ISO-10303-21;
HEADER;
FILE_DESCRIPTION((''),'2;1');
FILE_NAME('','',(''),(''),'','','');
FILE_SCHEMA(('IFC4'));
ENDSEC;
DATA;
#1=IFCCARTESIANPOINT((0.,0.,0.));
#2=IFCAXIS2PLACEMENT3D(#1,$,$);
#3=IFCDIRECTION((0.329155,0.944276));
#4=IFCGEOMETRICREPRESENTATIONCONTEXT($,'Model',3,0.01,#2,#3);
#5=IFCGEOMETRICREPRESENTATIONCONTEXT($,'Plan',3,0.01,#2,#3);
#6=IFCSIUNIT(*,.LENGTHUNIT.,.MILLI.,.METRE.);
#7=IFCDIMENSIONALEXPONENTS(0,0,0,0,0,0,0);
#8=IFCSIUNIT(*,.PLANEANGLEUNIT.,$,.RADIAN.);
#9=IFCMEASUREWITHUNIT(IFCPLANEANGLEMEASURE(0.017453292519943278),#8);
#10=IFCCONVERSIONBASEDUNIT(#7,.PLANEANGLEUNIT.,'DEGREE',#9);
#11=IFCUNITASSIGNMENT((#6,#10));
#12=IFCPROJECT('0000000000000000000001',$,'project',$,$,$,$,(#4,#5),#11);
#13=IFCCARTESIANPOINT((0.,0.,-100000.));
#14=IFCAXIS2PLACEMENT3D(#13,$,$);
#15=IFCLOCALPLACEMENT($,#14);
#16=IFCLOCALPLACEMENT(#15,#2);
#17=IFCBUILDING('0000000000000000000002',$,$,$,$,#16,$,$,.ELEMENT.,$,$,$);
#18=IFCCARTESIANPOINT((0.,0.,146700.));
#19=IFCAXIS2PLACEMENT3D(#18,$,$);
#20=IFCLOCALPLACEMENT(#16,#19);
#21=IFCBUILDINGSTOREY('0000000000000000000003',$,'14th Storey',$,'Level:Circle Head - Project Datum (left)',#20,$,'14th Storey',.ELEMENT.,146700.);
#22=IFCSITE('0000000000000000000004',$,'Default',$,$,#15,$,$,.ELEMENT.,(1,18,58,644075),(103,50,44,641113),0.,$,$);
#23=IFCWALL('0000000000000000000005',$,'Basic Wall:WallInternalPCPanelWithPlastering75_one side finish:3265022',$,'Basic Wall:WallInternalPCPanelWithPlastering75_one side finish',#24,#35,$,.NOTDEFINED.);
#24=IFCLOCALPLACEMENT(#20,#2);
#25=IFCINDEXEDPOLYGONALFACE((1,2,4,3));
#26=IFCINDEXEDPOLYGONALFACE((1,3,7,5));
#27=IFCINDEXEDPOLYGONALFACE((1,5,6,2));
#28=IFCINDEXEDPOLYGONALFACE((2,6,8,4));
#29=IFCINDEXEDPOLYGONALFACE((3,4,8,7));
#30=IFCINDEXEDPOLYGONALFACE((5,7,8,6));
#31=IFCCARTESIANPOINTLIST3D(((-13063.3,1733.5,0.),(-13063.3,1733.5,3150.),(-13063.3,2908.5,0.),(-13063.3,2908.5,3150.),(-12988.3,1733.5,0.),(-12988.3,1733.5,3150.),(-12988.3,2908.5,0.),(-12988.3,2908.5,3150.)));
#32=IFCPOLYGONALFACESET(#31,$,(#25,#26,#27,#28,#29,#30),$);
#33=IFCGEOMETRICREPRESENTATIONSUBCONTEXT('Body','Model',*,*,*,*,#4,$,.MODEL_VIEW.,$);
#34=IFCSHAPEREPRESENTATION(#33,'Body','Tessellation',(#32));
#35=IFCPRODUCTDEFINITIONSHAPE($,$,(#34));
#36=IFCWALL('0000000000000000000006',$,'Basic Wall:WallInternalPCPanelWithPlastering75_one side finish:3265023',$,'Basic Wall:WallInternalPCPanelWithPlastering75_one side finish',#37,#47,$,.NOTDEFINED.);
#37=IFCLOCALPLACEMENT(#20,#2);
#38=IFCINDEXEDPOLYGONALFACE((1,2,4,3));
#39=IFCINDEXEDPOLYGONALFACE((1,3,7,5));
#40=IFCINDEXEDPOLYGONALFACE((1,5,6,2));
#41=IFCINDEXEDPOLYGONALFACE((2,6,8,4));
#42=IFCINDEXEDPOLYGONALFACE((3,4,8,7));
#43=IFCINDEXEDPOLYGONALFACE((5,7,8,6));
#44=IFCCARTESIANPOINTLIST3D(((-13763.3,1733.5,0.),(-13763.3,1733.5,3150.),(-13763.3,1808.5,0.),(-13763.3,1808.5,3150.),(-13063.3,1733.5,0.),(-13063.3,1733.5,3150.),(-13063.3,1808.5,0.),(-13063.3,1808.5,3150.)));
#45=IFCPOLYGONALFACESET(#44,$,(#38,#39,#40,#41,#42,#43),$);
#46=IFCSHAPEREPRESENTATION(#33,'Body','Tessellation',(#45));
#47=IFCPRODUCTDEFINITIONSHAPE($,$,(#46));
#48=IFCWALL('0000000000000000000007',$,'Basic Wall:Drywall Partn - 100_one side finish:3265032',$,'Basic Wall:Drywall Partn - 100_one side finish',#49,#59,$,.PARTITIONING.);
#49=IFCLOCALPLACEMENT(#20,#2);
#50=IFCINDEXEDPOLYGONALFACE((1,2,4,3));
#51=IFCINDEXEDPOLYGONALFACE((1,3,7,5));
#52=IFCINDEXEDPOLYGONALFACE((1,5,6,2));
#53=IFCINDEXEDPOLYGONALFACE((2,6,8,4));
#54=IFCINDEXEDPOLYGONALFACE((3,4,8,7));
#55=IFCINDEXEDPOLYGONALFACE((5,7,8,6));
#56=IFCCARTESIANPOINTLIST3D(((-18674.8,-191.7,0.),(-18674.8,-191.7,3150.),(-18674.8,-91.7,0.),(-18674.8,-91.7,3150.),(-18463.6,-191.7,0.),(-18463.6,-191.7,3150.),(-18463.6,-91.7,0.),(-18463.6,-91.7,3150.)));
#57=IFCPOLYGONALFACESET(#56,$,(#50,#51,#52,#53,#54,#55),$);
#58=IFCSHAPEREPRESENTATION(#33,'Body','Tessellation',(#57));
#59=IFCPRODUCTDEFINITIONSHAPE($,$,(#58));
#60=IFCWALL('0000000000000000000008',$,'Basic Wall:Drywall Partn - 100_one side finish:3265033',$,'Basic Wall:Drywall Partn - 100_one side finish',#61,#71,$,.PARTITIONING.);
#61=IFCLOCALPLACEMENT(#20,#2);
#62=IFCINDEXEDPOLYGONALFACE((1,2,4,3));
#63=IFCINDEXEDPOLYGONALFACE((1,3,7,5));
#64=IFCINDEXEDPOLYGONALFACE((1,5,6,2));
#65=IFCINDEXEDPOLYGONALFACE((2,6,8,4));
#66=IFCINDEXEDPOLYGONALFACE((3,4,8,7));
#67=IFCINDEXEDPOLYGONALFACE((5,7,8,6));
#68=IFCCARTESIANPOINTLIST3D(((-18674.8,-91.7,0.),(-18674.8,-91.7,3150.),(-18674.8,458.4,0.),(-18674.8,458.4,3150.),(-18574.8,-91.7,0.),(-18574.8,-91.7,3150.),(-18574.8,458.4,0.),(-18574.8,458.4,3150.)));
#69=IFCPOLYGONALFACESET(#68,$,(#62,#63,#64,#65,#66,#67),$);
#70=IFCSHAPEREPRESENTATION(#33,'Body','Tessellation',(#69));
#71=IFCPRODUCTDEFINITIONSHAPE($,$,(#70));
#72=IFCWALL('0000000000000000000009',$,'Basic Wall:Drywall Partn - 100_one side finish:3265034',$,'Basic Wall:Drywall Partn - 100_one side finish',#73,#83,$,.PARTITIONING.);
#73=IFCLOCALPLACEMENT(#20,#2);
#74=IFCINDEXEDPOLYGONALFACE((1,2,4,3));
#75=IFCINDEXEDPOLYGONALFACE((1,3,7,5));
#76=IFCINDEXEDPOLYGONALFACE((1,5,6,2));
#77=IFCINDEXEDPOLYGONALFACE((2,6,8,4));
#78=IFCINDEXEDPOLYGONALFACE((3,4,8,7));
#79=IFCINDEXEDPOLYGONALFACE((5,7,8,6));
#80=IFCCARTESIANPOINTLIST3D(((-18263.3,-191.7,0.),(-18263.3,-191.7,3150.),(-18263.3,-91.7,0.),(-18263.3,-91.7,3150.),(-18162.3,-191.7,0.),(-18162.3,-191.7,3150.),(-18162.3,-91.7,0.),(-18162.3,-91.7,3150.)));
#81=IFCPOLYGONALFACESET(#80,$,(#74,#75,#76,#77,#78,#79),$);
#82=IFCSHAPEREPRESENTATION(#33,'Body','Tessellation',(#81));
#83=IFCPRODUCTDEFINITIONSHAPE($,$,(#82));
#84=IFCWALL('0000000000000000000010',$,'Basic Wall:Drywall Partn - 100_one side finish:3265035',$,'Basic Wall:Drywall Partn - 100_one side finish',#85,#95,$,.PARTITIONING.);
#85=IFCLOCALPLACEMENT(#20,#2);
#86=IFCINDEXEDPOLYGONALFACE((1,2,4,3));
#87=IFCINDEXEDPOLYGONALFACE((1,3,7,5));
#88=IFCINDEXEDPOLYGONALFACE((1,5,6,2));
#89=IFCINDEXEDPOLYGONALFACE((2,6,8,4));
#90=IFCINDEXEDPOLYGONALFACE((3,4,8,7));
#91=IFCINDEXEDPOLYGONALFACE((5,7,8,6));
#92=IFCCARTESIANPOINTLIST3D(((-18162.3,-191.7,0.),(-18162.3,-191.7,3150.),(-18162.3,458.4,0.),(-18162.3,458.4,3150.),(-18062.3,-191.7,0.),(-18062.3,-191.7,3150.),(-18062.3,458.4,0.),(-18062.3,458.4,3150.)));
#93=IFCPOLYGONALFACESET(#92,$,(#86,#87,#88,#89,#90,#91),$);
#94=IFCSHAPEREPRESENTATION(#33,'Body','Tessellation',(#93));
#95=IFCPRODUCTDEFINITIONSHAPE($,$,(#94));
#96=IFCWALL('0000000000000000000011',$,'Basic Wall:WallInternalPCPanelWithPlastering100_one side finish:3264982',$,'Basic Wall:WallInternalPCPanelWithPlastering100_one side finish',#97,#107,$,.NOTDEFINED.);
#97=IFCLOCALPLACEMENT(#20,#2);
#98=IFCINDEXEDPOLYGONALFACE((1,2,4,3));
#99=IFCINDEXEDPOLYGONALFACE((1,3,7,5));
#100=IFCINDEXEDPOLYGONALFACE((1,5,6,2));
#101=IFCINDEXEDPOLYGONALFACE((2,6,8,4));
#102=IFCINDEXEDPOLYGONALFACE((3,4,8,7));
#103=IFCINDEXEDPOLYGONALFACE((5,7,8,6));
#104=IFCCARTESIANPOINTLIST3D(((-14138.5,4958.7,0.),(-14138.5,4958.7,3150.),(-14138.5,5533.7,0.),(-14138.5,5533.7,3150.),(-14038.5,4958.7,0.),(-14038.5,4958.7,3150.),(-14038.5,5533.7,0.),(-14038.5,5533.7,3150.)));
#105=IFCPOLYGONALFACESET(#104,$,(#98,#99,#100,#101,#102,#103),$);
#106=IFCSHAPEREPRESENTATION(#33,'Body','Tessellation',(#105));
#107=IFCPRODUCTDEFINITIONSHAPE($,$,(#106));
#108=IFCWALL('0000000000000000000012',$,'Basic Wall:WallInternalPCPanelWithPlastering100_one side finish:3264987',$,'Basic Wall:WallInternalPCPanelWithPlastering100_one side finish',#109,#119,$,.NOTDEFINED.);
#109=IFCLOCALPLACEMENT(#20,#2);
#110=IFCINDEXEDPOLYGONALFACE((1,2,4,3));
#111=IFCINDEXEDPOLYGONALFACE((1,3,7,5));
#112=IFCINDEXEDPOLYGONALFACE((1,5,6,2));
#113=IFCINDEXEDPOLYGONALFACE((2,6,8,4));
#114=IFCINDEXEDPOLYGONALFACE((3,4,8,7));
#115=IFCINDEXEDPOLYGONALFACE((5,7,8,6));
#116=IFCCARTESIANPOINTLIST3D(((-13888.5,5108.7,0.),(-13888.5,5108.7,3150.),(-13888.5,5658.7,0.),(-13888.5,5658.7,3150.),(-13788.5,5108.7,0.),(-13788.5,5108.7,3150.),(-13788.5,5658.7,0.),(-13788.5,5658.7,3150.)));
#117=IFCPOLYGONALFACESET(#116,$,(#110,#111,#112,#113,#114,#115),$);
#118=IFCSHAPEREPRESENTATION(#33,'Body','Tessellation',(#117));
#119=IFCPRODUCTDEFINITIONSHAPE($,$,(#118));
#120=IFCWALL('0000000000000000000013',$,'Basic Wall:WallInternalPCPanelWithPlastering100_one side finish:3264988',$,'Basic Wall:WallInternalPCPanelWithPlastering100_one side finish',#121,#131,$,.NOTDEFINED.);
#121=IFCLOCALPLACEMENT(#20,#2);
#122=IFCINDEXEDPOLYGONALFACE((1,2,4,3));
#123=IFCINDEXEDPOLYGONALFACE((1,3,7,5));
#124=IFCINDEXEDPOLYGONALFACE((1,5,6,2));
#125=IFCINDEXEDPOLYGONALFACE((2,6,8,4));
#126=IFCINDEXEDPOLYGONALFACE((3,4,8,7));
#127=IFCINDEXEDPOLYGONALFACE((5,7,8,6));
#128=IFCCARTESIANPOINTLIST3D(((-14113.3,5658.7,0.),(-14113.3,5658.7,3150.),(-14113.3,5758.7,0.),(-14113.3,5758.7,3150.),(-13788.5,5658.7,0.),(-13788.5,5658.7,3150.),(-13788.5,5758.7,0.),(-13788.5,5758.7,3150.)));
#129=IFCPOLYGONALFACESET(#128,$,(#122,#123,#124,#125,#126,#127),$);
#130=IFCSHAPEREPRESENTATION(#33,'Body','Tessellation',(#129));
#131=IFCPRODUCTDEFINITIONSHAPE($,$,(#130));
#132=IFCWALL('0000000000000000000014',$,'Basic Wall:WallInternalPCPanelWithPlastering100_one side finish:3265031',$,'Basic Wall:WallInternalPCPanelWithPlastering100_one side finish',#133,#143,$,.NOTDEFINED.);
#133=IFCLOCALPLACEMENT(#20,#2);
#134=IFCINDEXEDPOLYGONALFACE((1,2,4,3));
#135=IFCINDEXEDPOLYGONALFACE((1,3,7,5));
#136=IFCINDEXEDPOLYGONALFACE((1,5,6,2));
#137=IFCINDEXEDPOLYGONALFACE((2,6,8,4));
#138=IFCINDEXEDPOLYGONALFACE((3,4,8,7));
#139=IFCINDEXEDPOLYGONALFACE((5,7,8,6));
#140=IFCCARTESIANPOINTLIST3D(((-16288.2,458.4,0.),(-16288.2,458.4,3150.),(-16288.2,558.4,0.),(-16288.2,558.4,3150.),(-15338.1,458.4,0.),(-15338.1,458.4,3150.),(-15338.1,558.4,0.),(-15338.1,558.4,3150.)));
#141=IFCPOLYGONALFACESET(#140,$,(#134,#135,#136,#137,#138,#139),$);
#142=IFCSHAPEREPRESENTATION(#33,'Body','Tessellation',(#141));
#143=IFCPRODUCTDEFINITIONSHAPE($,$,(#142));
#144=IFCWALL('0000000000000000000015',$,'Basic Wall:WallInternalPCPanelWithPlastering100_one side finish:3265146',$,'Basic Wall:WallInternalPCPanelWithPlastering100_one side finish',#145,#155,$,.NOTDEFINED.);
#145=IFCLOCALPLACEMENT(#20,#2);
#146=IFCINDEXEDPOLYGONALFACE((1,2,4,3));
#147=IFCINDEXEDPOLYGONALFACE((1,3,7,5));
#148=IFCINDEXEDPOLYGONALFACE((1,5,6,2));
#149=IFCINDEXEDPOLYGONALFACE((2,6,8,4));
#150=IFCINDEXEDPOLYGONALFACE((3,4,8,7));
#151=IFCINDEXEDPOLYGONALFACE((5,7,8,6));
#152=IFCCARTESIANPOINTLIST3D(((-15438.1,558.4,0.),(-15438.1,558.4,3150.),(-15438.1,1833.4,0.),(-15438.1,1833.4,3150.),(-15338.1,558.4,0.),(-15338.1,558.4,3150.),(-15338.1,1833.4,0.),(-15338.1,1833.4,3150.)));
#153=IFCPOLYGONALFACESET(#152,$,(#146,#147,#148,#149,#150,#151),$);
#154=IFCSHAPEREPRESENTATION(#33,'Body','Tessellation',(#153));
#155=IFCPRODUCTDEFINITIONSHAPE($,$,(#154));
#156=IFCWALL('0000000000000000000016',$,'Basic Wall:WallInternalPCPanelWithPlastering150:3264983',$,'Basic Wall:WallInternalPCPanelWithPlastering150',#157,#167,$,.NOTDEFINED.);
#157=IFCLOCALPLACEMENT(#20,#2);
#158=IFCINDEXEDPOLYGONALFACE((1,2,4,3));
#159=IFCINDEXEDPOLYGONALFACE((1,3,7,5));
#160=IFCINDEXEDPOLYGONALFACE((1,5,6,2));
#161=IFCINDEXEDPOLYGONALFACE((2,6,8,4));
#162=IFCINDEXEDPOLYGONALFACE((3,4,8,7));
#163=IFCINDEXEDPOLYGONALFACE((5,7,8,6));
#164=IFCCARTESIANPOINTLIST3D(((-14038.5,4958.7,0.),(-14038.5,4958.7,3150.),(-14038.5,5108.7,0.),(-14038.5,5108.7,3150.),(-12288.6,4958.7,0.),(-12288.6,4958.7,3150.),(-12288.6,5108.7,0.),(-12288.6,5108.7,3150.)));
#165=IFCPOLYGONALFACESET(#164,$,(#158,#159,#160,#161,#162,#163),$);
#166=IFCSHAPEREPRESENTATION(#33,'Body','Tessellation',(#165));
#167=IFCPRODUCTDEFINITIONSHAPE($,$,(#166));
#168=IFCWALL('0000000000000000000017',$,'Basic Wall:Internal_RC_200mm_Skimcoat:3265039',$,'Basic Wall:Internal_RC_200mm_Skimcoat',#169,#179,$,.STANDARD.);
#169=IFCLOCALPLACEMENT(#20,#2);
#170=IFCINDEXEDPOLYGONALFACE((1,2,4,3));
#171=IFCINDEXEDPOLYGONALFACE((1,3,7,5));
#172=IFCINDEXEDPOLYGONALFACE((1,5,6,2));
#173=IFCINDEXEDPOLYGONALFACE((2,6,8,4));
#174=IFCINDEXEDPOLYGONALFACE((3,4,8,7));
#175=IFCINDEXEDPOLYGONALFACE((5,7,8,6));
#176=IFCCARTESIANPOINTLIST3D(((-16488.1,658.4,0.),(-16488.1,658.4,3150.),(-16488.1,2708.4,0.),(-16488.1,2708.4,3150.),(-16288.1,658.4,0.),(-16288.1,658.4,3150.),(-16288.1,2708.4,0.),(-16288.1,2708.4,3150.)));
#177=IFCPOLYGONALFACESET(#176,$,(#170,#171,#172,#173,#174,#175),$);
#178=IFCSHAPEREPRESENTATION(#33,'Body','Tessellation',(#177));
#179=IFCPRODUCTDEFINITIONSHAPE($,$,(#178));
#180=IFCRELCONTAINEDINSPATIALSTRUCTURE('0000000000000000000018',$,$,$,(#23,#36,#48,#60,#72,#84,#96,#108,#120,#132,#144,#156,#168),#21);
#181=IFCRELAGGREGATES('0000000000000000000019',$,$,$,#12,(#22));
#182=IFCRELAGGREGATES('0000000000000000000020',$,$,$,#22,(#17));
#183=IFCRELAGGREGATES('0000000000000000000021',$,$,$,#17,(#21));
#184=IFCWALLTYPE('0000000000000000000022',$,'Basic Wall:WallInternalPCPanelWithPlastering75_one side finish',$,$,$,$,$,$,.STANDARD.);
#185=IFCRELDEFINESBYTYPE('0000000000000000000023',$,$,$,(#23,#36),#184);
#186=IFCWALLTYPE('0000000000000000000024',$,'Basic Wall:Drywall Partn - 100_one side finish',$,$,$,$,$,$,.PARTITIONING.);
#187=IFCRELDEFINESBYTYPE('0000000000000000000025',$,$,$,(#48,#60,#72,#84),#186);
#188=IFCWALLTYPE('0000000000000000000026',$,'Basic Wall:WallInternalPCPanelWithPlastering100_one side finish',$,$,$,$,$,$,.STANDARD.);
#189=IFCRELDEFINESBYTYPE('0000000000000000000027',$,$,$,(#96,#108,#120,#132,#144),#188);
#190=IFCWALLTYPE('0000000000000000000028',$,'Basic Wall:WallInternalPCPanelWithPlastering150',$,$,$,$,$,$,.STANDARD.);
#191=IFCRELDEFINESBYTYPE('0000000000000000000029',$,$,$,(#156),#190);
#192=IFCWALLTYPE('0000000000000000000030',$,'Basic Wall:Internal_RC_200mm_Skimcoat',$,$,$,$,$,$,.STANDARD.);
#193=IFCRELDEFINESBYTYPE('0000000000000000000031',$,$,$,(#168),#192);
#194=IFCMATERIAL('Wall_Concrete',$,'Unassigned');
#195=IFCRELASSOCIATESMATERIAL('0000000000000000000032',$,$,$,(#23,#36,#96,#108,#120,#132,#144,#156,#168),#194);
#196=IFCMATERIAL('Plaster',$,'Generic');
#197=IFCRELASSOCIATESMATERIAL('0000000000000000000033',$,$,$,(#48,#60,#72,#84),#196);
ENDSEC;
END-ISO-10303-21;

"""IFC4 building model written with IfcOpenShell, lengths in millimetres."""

from ifc_helpers import new_model, entity, si_unit, converted_unit, direction, frame, origin, place, context, subcontext, project, spatial, indexed_curve, outline, extrude, material, type_object, element, save


model = new_model("IFC4")

# Units and contexts
model_context = context("Model", 3, precision=0.01, world=origin(), true_north=direction((0.329155, 0.944276)))
plan_context = context("Plan", 3, precision=0.01, world=origin(), true_north=direction((0.329155, 0.944276)))
body_context = subcontext(model_context, "Body", "Model", "MODEL_VIEW")
ifc_project = project(units=[si_unit("LENGTHUNIT", "METRE", prefix="MILLI"), converted_unit("PLANEANGLEUNIT", "DEGREE", entity("IfcPlaneAngleMeasure", 0.017453292519943278), si_unit("PLANEANGLEUNIT", "RADIAN"), dimensions=[0, 0, 0, 0, 0, 0, 0])], contexts=[model_context, plan_context])

# Site, building, storey
site_placement = place(None, frame((0.0, 0.0, -100000.0)))
site = spatial("IfcSite", under=ifc_project, at=site_placement, Name="Default", CompositionType="ELEMENT", RefLatitude=(1, 18, 58, 644075), RefLongitude=(103, 50, 44, 641113), RefElevation=0.0)
building_placement = place(site_placement, origin())
building = spatial("IfcBuilding", under=site, at=building_placement, CompositionType="ELEMENT")
storey_placement = place(building_placement, frame((0.0, 0.0, 146700.0)))
storey = spatial("IfcBuildingStorey", under=building, at=storey_placement, Name="14th Storey", ObjectType="Level:Circle Head - Project Datum (left)", LongName="14th Storey", CompositionType="ELEMENT", Elevation=146700.0)

# Walls
ifc_material_1 = material(Name="Wall_Concrete", Category="Unassigned")
wall_type_1 = type_object("IfcWallType", Name="Basic Wall:WallInternalPCPanelWithPlastering75_one side finish", PredefinedType="STANDARD")
wall_1_placement = place(storey_placement, frame((-13025.8, 2908.5, 0.0), z_axis=(0.0, 0.0, 1.0), x_axis=(0.0, -1.0, 0.0)))
element("IfcWall", 1, at=wall_1_placement, inside=storey, type_object=wall_type_1, material=ifc_material_1, Name="Basic Wall:WallInternalPCPanelWithPlastering75_one side finish:3265022", ObjectType="Basic Wall:WallInternalPCPanelWithPlastering75_one side finish", PredefinedType="NOTDEFINED", context=body_context, shape_type="SweptSolid", body=[
    extrude(outline(indexed_curve([(1175.0, 37.5), (0.0, 37.5), (0.0, -37.5), (1175.0, -37.5), (1175.0, 37.5)], self_intersect=False)), origin(), (0.0, 0.0, 1.0), 3150.0),
])
wall_2_placement = place(storey_placement, frame((-13063.3, 1771.0, 0.0), z_axis=(0.0, 0.0, 1.0), x_axis=(-1.0, 0.0, 0.0)))
element("IfcWall", 2, at=wall_2_placement, inside=storey, type_object=wall_type_1, material=ifc_material_1, Name="Basic Wall:WallInternalPCPanelWithPlastering75_one side finish:3265023", ObjectType="Basic Wall:WallInternalPCPanelWithPlastering75_one side finish", PredefinedType="NOTDEFINED", context=body_context, shape_type="SweptSolid", body=[
    extrude(outline(indexed_curve([(700.0, 37.5), (0.0, 37.5), (0.0, -37.5), (700.0, -37.5), (700.0, 37.5)], self_intersect=False)), origin(), (0.0, 0.0, 1.0), 3150.0),
])
ifc_material_2 = material(Name="Plaster", Category="Generic")
wall_type_2 = type_object("IfcWallType", Name="Basic Wall:Drywall Partn - 100_one side finish", PredefinedType="PARTITIONING")
wall_3_placement = place(storey_placement, frame((-18463.6, -141.7, 0.0), z_axis=(0.0, 0.0, 1.0), x_axis=(-1.0, 0.0, 0.0)))
element("IfcWall", 3, at=wall_3_placement, inside=storey, type_object=wall_type_2, material=ifc_material_2, Name="Basic Wall:Drywall Partn - 100_one side finish:3265032", ObjectType="Basic Wall:Drywall Partn - 100_one side finish", PredefinedType="PARTITIONING", context=body_context, shape_type="SweptSolid", body=[
    extrude(outline(indexed_curve([(211.2, 50.0), (0.0, 50.0), (0.0, -50.0), (211.2, -50.0), (211.2, 50.0)], self_intersect=False)), origin(), (0.0, 0.0, 1.0), 3150.0),
])
wall_4_placement = place(storey_placement, frame((-18624.8, -91.7, 0.0), z_axis=(0.0, 0.0, 1.0), x_axis=(0.0, 1.0, 0.0)))
element("IfcWall", 4, at=wall_4_placement, inside=storey, type_object=wall_type_2, material=ifc_material_2, Name="Basic Wall:Drywall Partn - 100_one side finish:3265033", ObjectType="Basic Wall:Drywall Partn - 100_one side finish", PredefinedType="PARTITIONING", context=body_context, shape_type="SweptSolid", body=[
    extrude(outline(indexed_curve([(550.1, 50.0), (0.0, 50.0), (0.0, -50.0), (550.1, -50.0), (550.1, 50.0)], self_intersect=False)), origin(), (0.0, 0.0, 1.0), 3150.0),
])
wall_5_placement = place(storey_placement, frame((-18162.3, -141.7, 0.0), z_axis=(0.0, 0.0, 1.0), x_axis=(-1.0, 0.0, 0.0)))
element("IfcWall", 5, at=wall_5_placement, inside=storey, type_object=wall_type_2, material=ifc_material_2, Name="Basic Wall:Drywall Partn - 100_one side finish:3265034", ObjectType="Basic Wall:Drywall Partn - 100_one side finish", PredefinedType="PARTITIONING", context=body_context, shape_type="SweptSolid", body=[
    extrude(outline(indexed_curve([(101.0, 50.0), (0.0, 50.0), (0.0, -50.0), (101.0, -50.0), (101.0, 50.0)], self_intersect=False)), origin(), (0.0, 0.0, 1.0), 3150.0),
])
wall_6_placement = place(storey_placement, frame((-18112.3, 458.4, 0.0), z_axis=(0.0, 0.0, 1.0), x_axis=(0.0, -1.0, 0.0)))
element("IfcWall", 6, at=wall_6_placement, inside=storey, type_object=wall_type_2, material=ifc_material_2, Name="Basic Wall:Drywall Partn - 100_one side finish:3265035", ObjectType="Basic Wall:Drywall Partn - 100_one side finish", PredefinedType="PARTITIONING", context=body_context, shape_type="SweptSolid", body=[
    extrude(outline(indexed_curve([(650.1, 50.0), (0.0, 50.0), (0.0, -50.0), (650.1, -50.0), (650.1, 50.0)], self_intersect=False)), origin(), (0.0, 0.0, 1.0), 3150.0),
])
wall_type_3 = type_object("IfcWallType", Name="Basic Wall:WallInternalPCPanelWithPlastering100_one side finish", PredefinedType="STANDARD")
wall_7_placement = place(storey_placement, frame((-14088.5, 5533.7, 0.0), z_axis=(0.0, 0.0, 1.0), x_axis=(0.0, -1.0, 0.0)))
element("IfcWall", 7, at=wall_7_placement, inside=storey, type_object=wall_type_3, material=ifc_material_1, Name="Basic Wall:WallInternalPCPanelWithPlastering100_one side finish:3264982", ObjectType="Basic Wall:WallInternalPCPanelWithPlastering100_one side finish", PredefinedType="NOTDEFINED", context=body_context, shape_type="SweptSolid", body=[
    extrude(outline(indexed_curve([(575.0, 50.0), (0.0, 50.0), (0.0, -50.0), (575.0, -50.0), (575.0, 50.0)], self_intersect=False)), origin(), (0.0, 0.0, 1.0), 3150.0),
])
wall_8_placement = place(storey_placement, frame((-13838.5, 5108.7, 0.0), z_axis=(0.0, 0.0, 1.0), x_axis=(0.0, 1.0, 0.0)))
element("IfcWall", 8, at=wall_8_placement, inside=storey, type_object=wall_type_3, material=ifc_material_1, Name="Basic Wall:WallInternalPCPanelWithPlastering100_one side finish:3264987", ObjectType="Basic Wall:WallInternalPCPanelWithPlastering100_one side finish", PredefinedType="NOTDEFINED", context=body_context, shape_type="SweptSolid", body=[
    extrude(outline(indexed_curve([(550.0, 50.0), (0.0, 50.0), (0.0, -50.0), (550.0, -50.0), (550.0, 50.0)], self_intersect=False)), origin(), (0.0, 0.0, 1.0), 3150.0),
])
wall_9_placement = place(storey_placement, frame((-13788.5, 5708.7, 0.0), z_axis=(0.0, 0.0, 1.0), x_axis=(-1.0, 0.0, 0.0)))
element("IfcWall", 9, at=wall_9_placement, inside=storey, type_object=wall_type_3, material=ifc_material_1, Name="Basic Wall:WallInternalPCPanelWithPlastering100_one side finish:3264988", ObjectType="Basic Wall:WallInternalPCPanelWithPlastering100_one side finish", PredefinedType="NOTDEFINED", context=body_context, shape_type="SweptSolid", body=[
    extrude(outline(indexed_curve([(324.9, 50.0), (0.0, 50.0), (0.0, -50.0), (324.9, -50.0), (324.9, 50.0)], self_intersect=False)), origin(), (0.0, 0.0, 1.0), 3150.0),
])
wall_10_placement = place(storey_placement, frame((-15338.1, 508.4, 0.0), z_axis=(0.0, 0.0, 1.0), x_axis=(-1.0, 0.0, 0.0)))
element("IfcWall", 10, at=wall_10_placement, inside=storey, type_object=wall_type_3, material=ifc_material_1, Name="Basic Wall:WallInternalPCPanelWithPlastering100_one side finish:3265031", ObjectType="Basic Wall:WallInternalPCPanelWithPlastering100_one side finish", PredefinedType="NOTDEFINED", context=body_context, shape_type="SweptSolid", body=[
    extrude(outline(indexed_curve([(950.2, 50.0), (0.0, 50.0), (0.0, -50.0), (950.2, -50.0), (950.2, 50.0)], self_intersect=False)), origin(), (0.0, 0.0, 1.0), 3150.0),
])
wall_11_placement = place(storey_placement, frame((-15388.1, 558.4, 0.0), z_axis=(0.0, 0.0, 1.0), x_axis=(0.0, 1.0, 0.0)))
element("IfcWall", 11, at=wall_11_placement, inside=storey, type_object=wall_type_3, material=ifc_material_1, Name="Basic Wall:WallInternalPCPanelWithPlastering100_one side finish:3265146", ObjectType="Basic Wall:WallInternalPCPanelWithPlastering100_one side finish", PredefinedType="NOTDEFINED", context=body_context, shape_type="SweptSolid", body=[
    extrude(outline(indexed_curve([(1275.0, 50.0), (0.0, 50.0), (0.0, -50.0), (1275.0, -50.0), (1275.0, 50.0)], self_intersect=False)), origin(), (0.0, 0.0, 1.0), 3150.0),
])
wall_type_4 = type_object("IfcWallType", Name="Basic Wall:WallInternalPCPanelWithPlastering150", PredefinedType="STANDARD")
wall_12_placement = place(storey_placement, frame((-14038.5, 5033.7, 0.0)))
element("IfcWall", 12, at=wall_12_placement, inside=storey, type_object=wall_type_4, material=ifc_material_1, Name="Basic Wall:WallInternalPCPanelWithPlastering150:3264983", ObjectType="Basic Wall:WallInternalPCPanelWithPlastering150", PredefinedType="NOTDEFINED", context=body_context, shape_type="SweptSolid", body=[
    extrude(outline(indexed_curve([(1749.9, 75.0), (0.0, 75.0), (0.0, -75.0), (1749.9, -75.0), (1749.9, 75.0)], self_intersect=False)), origin(), (0.0, 0.0, 1.0), 3150.0),
])
wall_type_5 = type_object("IfcWallType", Name="Basic Wall:Internal_RC_200mm_Skimcoat", PredefinedType="STANDARD")
wall_13_placement = place(storey_placement, frame((-16388.1, 658.4, 0.0), z_axis=(0.0, 0.0, 1.0), x_axis=(0.0, 1.0, 0.0)))
element("IfcWall", 13, at=wall_13_placement, inside=storey, type_object=wall_type_5, material=ifc_material_1, Name="Basic Wall:Internal_RC_200mm_Skimcoat:3265039", ObjectType="Basic Wall:Internal_RC_200mm_Skimcoat", PredefinedType="STANDARD", context=body_context, shape_type="SweptSolid", body=[
    extrude(outline(indexed_curve([(2050.0, 100.0), (0.0, 100.0), (0.0, -100.0), (2050.0, -100.0), (2050.0, 100.0)], self_intersect=False)), origin(), (0.0, 0.0, 1.0), 3150.0),
])

save(model, "model.ifc")
